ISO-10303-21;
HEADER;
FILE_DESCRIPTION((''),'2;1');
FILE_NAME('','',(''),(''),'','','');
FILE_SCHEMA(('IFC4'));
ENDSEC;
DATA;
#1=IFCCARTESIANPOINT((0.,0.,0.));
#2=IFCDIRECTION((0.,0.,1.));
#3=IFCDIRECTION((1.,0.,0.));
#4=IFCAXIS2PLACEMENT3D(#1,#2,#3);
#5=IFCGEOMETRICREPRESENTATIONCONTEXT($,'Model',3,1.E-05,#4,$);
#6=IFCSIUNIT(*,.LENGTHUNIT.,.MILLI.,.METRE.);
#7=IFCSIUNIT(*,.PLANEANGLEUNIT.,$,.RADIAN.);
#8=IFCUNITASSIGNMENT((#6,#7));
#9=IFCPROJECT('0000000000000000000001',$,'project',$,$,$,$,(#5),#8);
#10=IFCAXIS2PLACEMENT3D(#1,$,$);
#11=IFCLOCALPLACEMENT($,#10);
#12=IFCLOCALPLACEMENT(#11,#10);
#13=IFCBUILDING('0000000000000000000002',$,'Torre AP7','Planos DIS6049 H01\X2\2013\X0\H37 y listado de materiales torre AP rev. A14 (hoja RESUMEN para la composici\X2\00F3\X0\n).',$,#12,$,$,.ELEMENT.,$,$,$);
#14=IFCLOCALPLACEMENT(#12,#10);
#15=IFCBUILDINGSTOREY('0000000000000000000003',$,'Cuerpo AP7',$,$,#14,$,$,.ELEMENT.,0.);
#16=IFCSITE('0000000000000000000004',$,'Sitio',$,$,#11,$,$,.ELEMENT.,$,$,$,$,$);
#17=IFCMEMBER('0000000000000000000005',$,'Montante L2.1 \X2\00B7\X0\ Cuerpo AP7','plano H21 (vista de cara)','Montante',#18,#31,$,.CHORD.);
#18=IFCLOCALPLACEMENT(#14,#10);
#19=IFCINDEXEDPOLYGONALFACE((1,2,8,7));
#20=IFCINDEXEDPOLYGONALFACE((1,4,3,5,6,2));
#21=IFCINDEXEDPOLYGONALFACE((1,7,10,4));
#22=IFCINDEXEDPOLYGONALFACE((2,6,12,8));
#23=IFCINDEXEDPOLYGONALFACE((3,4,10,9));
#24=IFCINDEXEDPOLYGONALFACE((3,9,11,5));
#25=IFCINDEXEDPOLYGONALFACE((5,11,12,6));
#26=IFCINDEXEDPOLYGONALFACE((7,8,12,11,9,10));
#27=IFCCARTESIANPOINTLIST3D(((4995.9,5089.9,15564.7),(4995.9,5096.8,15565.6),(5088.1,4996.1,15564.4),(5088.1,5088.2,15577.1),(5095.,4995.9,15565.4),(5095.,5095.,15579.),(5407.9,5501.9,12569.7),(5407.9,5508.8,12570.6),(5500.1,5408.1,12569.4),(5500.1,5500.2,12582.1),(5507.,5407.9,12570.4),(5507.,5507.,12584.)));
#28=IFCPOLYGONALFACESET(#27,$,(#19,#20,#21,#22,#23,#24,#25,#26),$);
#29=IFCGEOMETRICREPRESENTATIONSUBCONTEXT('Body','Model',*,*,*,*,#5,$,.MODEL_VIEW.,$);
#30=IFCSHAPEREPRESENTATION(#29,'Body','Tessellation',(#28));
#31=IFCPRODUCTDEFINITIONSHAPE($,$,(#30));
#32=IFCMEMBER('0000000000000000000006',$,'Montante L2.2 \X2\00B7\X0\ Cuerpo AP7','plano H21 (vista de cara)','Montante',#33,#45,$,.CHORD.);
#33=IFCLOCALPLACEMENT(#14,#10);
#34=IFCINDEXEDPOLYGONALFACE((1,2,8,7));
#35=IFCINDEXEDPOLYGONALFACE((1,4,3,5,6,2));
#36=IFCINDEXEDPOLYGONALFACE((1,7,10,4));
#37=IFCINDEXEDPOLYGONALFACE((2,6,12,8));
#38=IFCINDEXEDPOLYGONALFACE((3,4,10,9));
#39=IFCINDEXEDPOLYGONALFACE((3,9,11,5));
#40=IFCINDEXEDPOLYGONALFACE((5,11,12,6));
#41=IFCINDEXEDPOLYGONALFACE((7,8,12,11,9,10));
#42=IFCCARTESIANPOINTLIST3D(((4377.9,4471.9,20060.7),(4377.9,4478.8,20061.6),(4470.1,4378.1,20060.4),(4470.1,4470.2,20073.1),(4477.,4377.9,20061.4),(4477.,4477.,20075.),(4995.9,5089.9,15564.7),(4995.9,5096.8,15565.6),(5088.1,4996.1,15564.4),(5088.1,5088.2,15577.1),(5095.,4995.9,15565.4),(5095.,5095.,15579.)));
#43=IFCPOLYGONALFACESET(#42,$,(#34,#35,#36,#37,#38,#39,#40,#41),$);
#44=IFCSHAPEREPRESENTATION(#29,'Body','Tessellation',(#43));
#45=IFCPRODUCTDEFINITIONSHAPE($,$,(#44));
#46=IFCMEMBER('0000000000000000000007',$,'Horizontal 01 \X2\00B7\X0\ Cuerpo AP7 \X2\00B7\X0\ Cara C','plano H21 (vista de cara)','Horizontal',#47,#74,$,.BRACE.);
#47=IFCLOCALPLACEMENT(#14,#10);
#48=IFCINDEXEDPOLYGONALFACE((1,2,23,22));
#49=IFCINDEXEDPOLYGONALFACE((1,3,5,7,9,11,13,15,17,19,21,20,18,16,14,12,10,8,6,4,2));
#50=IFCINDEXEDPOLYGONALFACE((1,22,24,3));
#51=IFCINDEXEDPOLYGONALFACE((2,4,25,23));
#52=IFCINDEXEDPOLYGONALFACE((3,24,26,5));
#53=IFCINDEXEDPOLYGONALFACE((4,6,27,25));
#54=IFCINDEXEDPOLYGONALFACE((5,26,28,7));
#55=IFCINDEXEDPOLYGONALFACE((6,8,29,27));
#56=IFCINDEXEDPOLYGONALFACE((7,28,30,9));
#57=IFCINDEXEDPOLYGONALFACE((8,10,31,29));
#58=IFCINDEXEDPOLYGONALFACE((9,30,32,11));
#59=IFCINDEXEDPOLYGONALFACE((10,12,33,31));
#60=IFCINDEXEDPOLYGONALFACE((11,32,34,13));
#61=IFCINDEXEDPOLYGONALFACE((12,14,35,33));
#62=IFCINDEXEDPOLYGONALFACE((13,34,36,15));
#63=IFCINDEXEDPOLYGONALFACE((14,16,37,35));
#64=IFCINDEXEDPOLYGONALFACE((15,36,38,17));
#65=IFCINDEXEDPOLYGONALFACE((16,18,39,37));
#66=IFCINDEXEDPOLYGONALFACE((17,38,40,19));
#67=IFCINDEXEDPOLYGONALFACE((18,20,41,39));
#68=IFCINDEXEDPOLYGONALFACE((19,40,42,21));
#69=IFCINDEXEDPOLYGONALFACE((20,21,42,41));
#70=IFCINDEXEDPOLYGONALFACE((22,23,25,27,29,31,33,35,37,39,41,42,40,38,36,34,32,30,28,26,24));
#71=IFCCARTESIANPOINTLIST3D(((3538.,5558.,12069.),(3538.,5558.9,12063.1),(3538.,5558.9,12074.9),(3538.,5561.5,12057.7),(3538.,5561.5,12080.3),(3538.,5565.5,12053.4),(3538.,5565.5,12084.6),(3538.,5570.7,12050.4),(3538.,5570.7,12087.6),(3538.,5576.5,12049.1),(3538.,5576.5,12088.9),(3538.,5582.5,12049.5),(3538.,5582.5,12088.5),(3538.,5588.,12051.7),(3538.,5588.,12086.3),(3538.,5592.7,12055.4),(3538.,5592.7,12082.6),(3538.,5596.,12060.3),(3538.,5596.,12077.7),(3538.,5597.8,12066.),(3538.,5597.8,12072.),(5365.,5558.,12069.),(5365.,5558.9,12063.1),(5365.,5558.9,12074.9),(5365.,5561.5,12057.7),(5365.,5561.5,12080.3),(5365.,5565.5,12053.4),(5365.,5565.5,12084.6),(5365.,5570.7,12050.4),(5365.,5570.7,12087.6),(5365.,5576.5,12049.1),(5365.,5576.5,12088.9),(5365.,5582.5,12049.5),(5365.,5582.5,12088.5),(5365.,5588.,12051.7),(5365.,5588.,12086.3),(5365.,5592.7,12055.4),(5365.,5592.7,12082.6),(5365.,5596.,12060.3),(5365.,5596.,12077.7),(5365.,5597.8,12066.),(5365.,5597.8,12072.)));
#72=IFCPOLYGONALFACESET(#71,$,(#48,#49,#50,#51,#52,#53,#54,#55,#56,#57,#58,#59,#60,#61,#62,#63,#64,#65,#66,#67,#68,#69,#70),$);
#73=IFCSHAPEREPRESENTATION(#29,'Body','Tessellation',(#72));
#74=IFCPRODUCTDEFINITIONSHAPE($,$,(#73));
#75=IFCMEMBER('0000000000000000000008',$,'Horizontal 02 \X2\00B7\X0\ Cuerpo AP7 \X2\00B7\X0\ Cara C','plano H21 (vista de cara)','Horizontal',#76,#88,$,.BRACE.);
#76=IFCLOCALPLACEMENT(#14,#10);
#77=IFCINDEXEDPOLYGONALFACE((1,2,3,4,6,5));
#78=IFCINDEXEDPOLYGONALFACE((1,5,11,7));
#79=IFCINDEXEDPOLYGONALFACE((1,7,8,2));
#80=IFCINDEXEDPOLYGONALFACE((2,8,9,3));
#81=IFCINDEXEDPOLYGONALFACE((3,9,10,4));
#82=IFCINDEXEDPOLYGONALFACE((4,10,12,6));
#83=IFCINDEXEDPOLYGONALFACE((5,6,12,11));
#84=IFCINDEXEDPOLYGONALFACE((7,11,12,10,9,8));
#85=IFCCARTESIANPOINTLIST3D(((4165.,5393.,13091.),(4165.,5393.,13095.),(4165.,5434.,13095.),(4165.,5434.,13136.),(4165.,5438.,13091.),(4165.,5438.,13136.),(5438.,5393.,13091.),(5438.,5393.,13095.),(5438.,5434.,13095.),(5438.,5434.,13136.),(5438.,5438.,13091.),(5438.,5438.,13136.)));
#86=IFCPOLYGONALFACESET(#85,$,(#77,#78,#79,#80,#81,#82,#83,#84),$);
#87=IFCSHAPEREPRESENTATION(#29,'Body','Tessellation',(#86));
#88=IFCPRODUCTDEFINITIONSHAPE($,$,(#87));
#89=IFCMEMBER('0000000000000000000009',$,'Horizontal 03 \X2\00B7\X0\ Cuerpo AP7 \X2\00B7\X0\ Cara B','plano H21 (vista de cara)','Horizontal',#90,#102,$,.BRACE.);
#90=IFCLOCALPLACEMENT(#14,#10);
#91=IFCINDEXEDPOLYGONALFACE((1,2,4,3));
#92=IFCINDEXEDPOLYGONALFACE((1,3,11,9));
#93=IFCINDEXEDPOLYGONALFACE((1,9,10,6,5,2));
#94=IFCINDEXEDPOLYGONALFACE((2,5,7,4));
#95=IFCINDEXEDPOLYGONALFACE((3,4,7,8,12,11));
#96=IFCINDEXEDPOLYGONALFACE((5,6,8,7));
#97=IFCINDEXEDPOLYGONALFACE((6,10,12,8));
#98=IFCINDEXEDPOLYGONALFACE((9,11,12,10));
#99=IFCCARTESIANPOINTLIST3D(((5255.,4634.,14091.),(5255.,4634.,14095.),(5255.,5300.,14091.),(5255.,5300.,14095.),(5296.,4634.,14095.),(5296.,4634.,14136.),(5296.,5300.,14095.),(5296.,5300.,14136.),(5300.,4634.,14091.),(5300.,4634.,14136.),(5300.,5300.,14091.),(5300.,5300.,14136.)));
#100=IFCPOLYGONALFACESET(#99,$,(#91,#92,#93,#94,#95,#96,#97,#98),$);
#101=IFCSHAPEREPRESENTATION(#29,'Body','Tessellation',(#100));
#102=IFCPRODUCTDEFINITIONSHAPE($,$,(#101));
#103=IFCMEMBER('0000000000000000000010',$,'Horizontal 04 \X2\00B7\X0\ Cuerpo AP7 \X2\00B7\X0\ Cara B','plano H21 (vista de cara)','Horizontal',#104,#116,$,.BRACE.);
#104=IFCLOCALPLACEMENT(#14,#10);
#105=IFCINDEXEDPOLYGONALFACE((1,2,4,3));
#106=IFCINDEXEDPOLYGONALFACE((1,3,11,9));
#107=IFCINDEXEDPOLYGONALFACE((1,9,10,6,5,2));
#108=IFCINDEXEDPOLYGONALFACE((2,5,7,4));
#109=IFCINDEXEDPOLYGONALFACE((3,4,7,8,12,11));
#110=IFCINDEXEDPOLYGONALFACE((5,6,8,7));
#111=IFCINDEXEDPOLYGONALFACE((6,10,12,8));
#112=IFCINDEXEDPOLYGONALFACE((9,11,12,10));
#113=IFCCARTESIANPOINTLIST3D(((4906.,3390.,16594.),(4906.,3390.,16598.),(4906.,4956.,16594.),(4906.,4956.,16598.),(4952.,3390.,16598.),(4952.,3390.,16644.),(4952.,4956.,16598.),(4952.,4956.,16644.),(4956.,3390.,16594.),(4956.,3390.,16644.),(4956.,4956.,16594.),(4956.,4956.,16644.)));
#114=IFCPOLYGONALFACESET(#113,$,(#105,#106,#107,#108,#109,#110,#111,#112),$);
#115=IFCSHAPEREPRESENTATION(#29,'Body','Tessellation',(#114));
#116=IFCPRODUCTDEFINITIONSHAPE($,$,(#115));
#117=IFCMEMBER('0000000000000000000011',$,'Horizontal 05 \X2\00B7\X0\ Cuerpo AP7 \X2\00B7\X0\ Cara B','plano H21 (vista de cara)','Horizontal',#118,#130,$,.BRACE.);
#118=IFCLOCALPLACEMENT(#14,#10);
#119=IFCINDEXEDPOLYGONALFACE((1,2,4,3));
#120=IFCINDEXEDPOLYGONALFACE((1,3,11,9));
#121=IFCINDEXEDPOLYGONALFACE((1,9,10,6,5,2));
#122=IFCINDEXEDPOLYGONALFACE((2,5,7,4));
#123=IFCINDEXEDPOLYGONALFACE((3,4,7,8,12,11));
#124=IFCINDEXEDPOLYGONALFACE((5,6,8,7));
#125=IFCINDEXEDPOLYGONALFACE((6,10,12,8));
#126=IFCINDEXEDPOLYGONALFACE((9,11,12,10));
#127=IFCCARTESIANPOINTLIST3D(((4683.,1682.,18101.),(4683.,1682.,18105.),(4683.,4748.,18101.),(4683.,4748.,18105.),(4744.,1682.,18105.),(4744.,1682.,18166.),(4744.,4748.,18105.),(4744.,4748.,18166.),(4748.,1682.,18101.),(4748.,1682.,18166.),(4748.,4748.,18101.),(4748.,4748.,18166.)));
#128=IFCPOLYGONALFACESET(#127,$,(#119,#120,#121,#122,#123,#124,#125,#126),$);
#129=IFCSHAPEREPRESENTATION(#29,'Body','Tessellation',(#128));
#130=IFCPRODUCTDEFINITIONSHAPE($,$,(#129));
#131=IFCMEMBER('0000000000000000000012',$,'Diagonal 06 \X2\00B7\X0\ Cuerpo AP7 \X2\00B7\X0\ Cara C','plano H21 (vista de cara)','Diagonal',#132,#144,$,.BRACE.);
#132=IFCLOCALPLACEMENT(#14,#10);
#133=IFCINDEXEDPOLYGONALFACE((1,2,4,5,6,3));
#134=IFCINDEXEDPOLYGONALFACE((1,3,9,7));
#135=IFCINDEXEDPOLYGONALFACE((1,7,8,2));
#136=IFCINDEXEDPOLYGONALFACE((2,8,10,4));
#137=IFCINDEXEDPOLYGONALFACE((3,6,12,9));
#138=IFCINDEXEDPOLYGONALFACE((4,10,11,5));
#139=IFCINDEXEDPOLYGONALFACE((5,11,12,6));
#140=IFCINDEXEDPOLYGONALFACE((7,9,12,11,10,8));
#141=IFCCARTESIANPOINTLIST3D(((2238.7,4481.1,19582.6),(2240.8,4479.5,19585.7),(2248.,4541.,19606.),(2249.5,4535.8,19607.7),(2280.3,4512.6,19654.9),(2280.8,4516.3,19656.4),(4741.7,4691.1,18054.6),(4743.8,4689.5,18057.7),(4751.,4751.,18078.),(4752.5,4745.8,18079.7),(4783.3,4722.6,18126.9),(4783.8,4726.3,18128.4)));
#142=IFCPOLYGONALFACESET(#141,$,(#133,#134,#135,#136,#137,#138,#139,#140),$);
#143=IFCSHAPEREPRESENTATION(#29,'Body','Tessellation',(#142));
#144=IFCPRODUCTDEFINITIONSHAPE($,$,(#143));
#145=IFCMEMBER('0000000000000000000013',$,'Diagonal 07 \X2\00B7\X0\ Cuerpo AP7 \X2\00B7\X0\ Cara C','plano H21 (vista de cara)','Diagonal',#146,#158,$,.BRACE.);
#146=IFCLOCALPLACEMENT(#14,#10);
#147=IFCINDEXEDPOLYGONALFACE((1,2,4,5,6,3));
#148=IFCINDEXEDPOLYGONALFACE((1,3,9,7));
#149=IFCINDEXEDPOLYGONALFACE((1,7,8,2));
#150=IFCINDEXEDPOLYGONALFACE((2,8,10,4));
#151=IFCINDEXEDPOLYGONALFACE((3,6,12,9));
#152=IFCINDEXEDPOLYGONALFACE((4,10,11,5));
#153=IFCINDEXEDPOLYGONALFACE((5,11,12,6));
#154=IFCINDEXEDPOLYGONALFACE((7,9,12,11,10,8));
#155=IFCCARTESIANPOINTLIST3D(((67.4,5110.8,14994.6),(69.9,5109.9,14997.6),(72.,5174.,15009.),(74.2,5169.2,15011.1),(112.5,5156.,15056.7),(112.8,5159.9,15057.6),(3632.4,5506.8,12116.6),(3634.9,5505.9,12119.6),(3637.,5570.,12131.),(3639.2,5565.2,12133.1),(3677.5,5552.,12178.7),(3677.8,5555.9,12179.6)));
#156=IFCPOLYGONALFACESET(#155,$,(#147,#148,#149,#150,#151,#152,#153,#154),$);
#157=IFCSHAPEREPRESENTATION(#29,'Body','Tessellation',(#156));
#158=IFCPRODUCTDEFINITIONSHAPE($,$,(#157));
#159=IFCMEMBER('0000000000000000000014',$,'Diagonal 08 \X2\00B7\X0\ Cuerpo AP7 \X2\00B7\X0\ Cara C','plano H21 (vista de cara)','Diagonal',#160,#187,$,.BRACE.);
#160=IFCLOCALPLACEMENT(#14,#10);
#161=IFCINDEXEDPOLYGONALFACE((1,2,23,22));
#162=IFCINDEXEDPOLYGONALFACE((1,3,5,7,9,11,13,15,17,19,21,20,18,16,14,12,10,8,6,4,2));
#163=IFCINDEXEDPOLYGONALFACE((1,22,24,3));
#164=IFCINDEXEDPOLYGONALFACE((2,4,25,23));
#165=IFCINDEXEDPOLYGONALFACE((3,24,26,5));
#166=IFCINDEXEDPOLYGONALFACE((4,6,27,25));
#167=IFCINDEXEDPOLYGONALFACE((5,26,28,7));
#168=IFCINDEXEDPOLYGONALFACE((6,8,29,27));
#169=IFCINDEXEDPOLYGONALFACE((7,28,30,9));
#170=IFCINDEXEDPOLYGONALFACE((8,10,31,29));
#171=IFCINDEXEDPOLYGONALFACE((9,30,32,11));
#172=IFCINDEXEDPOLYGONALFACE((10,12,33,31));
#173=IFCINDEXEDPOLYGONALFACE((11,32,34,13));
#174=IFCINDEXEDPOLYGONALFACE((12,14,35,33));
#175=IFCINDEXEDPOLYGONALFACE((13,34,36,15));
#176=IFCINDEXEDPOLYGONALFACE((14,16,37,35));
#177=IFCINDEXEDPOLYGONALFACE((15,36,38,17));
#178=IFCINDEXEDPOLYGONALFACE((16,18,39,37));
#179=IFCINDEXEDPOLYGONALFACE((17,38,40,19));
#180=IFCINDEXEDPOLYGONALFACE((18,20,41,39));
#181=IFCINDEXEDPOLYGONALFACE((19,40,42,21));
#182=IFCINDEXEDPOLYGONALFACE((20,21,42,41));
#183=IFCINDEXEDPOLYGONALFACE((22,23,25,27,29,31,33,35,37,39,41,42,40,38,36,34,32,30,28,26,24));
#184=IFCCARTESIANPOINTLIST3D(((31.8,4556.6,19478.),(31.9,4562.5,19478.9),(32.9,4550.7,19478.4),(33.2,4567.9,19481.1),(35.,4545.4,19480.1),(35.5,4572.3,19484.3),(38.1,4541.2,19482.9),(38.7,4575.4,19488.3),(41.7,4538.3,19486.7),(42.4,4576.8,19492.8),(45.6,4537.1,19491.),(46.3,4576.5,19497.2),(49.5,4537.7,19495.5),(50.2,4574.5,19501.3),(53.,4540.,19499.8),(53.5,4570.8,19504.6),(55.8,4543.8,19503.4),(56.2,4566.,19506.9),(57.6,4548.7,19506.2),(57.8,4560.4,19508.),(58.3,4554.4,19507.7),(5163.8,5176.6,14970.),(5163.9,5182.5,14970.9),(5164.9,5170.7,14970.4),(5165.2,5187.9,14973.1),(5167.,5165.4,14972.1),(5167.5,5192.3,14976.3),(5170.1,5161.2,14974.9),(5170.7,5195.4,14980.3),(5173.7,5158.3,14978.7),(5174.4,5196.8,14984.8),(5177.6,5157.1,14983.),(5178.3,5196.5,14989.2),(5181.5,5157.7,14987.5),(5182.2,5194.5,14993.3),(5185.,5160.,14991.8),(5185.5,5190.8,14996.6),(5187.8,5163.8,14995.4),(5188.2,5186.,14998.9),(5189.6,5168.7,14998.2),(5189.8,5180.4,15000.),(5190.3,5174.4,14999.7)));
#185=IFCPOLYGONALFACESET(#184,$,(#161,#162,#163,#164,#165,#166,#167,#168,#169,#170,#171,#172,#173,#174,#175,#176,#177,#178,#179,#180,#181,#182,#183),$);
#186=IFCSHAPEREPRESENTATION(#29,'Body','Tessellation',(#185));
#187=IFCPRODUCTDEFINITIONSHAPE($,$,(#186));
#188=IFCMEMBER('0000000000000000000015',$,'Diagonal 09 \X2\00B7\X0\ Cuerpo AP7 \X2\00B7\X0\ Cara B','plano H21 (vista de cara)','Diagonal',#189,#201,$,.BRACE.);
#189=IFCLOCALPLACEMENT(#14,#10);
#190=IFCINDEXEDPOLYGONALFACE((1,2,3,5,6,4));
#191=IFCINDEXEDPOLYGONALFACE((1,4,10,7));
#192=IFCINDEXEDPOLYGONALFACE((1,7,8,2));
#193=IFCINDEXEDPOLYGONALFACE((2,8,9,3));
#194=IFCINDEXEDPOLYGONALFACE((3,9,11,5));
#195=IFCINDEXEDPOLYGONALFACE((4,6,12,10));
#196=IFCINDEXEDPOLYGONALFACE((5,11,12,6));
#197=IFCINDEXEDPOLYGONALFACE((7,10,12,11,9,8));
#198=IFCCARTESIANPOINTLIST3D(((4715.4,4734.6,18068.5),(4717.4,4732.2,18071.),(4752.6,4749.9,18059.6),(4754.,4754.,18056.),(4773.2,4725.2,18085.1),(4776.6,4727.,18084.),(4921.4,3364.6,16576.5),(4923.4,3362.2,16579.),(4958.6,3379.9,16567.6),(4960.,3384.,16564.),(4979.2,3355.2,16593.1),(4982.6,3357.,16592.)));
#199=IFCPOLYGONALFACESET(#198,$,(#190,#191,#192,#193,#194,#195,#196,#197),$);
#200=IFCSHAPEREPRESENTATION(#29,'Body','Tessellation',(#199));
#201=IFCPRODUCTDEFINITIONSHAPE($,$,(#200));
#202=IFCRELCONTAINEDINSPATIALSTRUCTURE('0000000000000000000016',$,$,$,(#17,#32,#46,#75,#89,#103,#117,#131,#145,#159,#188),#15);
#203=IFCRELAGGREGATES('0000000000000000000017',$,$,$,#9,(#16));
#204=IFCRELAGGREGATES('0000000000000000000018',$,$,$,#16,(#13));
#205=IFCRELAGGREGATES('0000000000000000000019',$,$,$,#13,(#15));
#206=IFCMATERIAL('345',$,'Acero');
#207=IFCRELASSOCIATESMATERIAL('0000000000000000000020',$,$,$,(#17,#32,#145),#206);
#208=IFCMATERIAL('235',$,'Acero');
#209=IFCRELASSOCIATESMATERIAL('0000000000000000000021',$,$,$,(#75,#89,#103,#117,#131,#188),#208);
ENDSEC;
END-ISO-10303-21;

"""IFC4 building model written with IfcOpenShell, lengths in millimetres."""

from ifc_helpers import new_model, si_unit, frame, frame_2d, origin, origin_with_axes, place, context, subcontext, project, spatial, circle, l_section, extrude, material, element, save


model = new_model("IFC4")

# Units and contexts
model_context = context("Model", 3, precision=1e-05, world=origin_with_axes())
body_context = subcontext(model_context, "Body", "Model", "MODEL_VIEW")
ifc_project = project(units=[si_unit("LENGTHUNIT", "METRE", prefix="MILLI"), si_unit("PLANEANGLEUNIT", "RADIAN")], contexts=[model_context])

# Site, building, storey
site_placement = place(None, origin())
site = spatial("IfcSite", under=ifc_project, at=site_placement, Name="Sitio", CompositionType="ELEMENT")
building_placement = place(site_placement, origin())
building = spatial("IfcBuilding", under=site, at=building_placement, Name="Torre AP7", Description="Planos DIS6049 H01–H37 y listado de materiales torre AP rev. A14 (hoja RESUMEN para la composición).", CompositionType="ELEMENT")
storey_placement = place(building_placement, origin())
storey = spatial("IfcBuildingStorey", under=building, at=storey_placement, Name="Cuerpo AP7", CompositionType="ELEMENT", Elevation=0.0)

# Members
ifc_material_1 = material(Name="345", Category="Acero")
member_1_placement = place(storey_placement, frame((5507.0, 5507.0, 12584.0), z_axis=(-0.135031, -0.135031, 0.981597), x_axis=(-0.990841, 0.018402, -0.133771)))
element("IfcMember", 1, at=member_1_placement, inside=storey, material=ifc_material_1, Name="Montante L2.1 · Cuerpo AP7", Description="plano H21 (vista de cara)", ObjectType="Montante", PredefinedType="CHORD", context=body_context, shape_type="SweptSolid", body=[
    extrude(l_section(Depth=100.0, Width=100.0, Thickness=7.0, at=frame_2d((50.0, 50.0))), None, (0.0, 0.0, 1.0), 3051.1),
])
member_2_placement = place(storey_placement, frame((5095.0, 5095.0, 15579.0), z_axis=(-0.13493, -0.13493, 0.981625), x_axis=(-0.990855, 0.018374, -0.133673)))
element("IfcMember", 2, at=member_2_placement, inside=storey, material=ifc_material_1, Name="Montante L2.2 · Cuerpo AP7", Description="plano H21 (vista de cara)", ObjectType="Montante", PredefinedType="CHORD", context=body_context, shape_type="SweptSolid", body=[
    extrude(l_section(Depth=100.0, Width=100.0, Thickness=7.0, at=frame_2d((50.0, 50.0))), None, (0.0, 0.0, 1.0), 4580.2),
])
member_3_placement = place(storey_placement, frame((5365.0, 5578.0, 12069.0), z_axis=(-1.0, 0.0, 0.0), x_axis=(0.0, -1.0, 0.0)))
element("IfcMember", 3, at=member_3_placement, inside=storey, Name="Horizontal 01 · Cuerpo AP7 · Cara C", Description="plano H21 (vista de cara)", ObjectType="Horizontal", PredefinedType="BRACE", context=body_context, shape_type="SweptSolid", body=[
    extrude(circle(Radius=20.0), None, (0.0, 0.0, 1.0), 1827.0),
])
ifc_material_2 = material(Name="235", Category="Acero")
member_4_placement = place(storey_placement, frame((5438.0, 5438.0, 13091.0), z_axis=(-1.0, 0.0, 0.0), x_axis=(0.0, -1.0, 0.0)))
element("IfcMember", 4, at=member_4_placement, inside=storey, material=ifc_material_2, Name="Horizontal 02 · Cuerpo AP7 · Cara C", Description="plano H21 (vista de cara)", ObjectType="Horizontal", PredefinedType="BRACE", context=body_context, shape_type="SweptSolid", body=[
    extrude(l_section(Depth=45.0, Width=45.0, Thickness=4.0, at=frame_2d((22.5, 22.5))), None, (0.0, 0.0, 1.0), 1273.0),
])
member_5_placement = place(storey_placement, frame((5300.0, 4634.0, 14091.0), z_axis=(0.0, 1.0, 0.0), x_axis=(-1.0, 0.0, 0.0)))
element("IfcMember", 5, at=member_5_placement, inside=storey, material=ifc_material_2, Name="Horizontal 03 · Cuerpo AP7 · Cara B", Description="plano H21 (vista de cara)", ObjectType="Horizontal", PredefinedType="BRACE", context=body_context, shape_type="SweptSolid", body=[
    extrude(l_section(Depth=45.0, Width=45.0, Thickness=4.0, at=frame_2d((22.5, 22.5))), None, (0.0, 0.0, 1.0), 666.0),
])
member_6_placement = place(storey_placement, frame((4956.0, 3390.0, 16594.0), z_axis=(0.0, 1.0, 0.0), x_axis=(-1.0, 0.0, 0.0)))
element("IfcMember", 6, at=member_6_placement, inside=storey, material=ifc_material_2, Name="Horizontal 04 · Cuerpo AP7 · Cara B", Description="plano H21 (vista de cara)", ObjectType="Horizontal", PredefinedType="BRACE", context=body_context, shape_type="SweptSolid", body=[
    extrude(l_section(Depth=50.0, Width=50.0, Thickness=4.0, at=frame_2d((25.0, 25.0))), None, (0.0, 0.0, 1.0), 1566.0),
])
member_7_placement = place(storey_placement, frame((4748.0, 1682.0, 18101.0), z_axis=(0.0, 1.0, 0.0), x_axis=(-1.0, 0.0, 0.0)))
element("IfcMember", 7, at=member_7_placement, inside=storey, material=ifc_material_2, Name="Horizontal 05 · Cuerpo AP7 · Cara B", Description="plano H21 (vista de cara)", ObjectType="Horizontal", PredefinedType="BRACE", context=body_context, shape_type="SweptSolid", body=[
    extrude(l_section(Depth=65.0, Width=65.0, Thickness=4.0, at=frame_2d((32.5, 32.5))), None, (0.0, 0.0, 1.0), 3066.0),
])
member_8_placement = place(storey_placement, frame((4751.0, 4751.0, 18078.0), z_axis=(-0.851346, -0.071427, 0.519719), x_axis=(-0.142318, -0.922089, -0.359857)))
element("IfcMember", 8, at=member_8_placement, inside=storey, material=ifc_material_2, Name="Diagonal 06 · Cuerpo AP7 · Cara C", Description="plano H21 (vista de cara)", ObjectType="Diagonal", PredefinedType="BRACE", context=body_context, shape_type="SweptSolid", body=[
    extrude(l_section(Depth=65.0, Width=65.0, Thickness=4.0, at=frame_2d((32.5, 32.5))), None, (0.0, 0.0, 1.0), 2940.0),
])
member_9_placement = place(storey_placement, frame((3637.0, 5570.0, 12131.0), z_axis=(-0.775203, -0.086109, 0.625816), x_axis=(-0.071222, -0.972436, -0.222026)))
element("IfcMember", 9, at=member_9_placement, inside=storey, material=ifc_material_1, Name="Diagonal 07 · Cuerpo AP7 · Cara C", Description="plano H21 (vista de cara)", ObjectType="Diagonal", PredefinedType="BRACE", context=body_context, shape_type="SweptSolid", body=[
    extrude(l_section(Depth=65.0, Width=65.0, Thickness=4.0, at=frame_2d((32.5, 32.5))), None, (0.0, 0.0, 1.0), 4598.8),
])
member_10_placement = place(storey_placement, frame((5177.0, 5177.0, 14985.0), z_axis=(-0.74823, -0.090394, 0.657253), x_axis=(-0.164751, -0.934326, -0.316057)))
element("IfcMember", 10, at=member_10_placement, inside=storey, Name="Diagonal 08 · Cuerpo AP7 · Cara C", Description="plano H21 (vista de cara)", ObjectType="Diagonal", PredefinedType="BRACE", context=body_context, shape_type="SweptSolid", body=[
    extrude(circle(Radius=20.0), None, (0.0, 0.0, 1.0), 6858.9),
])
member_11_placement = place(storey_placement, frame((4960.0, 3384.0, 16564.0), z_axis=(-0.101178, 0.67288, 0.7328), x_axis=(-0.858174, -0.431654, 0.27787)))
element("IfcMember", 11, at=member_11_placement, inside=storey, material=ifc_material_2, Name="Diagonal 09 · Cuerpo AP7 · Cara B", Description="plano H21 (vista de cara)", ObjectType="Diagonal", PredefinedType="BRACE", context=body_context, shape_type="SweptSolid", body=[
    extrude(l_section(Depth=45.0, Width=45.0, Thickness=4.0, at=frame_2d((22.5, 22.5))), None, (0.0, 0.0, 1.0), 2036.0),
])

save(model, "model.ifc")
